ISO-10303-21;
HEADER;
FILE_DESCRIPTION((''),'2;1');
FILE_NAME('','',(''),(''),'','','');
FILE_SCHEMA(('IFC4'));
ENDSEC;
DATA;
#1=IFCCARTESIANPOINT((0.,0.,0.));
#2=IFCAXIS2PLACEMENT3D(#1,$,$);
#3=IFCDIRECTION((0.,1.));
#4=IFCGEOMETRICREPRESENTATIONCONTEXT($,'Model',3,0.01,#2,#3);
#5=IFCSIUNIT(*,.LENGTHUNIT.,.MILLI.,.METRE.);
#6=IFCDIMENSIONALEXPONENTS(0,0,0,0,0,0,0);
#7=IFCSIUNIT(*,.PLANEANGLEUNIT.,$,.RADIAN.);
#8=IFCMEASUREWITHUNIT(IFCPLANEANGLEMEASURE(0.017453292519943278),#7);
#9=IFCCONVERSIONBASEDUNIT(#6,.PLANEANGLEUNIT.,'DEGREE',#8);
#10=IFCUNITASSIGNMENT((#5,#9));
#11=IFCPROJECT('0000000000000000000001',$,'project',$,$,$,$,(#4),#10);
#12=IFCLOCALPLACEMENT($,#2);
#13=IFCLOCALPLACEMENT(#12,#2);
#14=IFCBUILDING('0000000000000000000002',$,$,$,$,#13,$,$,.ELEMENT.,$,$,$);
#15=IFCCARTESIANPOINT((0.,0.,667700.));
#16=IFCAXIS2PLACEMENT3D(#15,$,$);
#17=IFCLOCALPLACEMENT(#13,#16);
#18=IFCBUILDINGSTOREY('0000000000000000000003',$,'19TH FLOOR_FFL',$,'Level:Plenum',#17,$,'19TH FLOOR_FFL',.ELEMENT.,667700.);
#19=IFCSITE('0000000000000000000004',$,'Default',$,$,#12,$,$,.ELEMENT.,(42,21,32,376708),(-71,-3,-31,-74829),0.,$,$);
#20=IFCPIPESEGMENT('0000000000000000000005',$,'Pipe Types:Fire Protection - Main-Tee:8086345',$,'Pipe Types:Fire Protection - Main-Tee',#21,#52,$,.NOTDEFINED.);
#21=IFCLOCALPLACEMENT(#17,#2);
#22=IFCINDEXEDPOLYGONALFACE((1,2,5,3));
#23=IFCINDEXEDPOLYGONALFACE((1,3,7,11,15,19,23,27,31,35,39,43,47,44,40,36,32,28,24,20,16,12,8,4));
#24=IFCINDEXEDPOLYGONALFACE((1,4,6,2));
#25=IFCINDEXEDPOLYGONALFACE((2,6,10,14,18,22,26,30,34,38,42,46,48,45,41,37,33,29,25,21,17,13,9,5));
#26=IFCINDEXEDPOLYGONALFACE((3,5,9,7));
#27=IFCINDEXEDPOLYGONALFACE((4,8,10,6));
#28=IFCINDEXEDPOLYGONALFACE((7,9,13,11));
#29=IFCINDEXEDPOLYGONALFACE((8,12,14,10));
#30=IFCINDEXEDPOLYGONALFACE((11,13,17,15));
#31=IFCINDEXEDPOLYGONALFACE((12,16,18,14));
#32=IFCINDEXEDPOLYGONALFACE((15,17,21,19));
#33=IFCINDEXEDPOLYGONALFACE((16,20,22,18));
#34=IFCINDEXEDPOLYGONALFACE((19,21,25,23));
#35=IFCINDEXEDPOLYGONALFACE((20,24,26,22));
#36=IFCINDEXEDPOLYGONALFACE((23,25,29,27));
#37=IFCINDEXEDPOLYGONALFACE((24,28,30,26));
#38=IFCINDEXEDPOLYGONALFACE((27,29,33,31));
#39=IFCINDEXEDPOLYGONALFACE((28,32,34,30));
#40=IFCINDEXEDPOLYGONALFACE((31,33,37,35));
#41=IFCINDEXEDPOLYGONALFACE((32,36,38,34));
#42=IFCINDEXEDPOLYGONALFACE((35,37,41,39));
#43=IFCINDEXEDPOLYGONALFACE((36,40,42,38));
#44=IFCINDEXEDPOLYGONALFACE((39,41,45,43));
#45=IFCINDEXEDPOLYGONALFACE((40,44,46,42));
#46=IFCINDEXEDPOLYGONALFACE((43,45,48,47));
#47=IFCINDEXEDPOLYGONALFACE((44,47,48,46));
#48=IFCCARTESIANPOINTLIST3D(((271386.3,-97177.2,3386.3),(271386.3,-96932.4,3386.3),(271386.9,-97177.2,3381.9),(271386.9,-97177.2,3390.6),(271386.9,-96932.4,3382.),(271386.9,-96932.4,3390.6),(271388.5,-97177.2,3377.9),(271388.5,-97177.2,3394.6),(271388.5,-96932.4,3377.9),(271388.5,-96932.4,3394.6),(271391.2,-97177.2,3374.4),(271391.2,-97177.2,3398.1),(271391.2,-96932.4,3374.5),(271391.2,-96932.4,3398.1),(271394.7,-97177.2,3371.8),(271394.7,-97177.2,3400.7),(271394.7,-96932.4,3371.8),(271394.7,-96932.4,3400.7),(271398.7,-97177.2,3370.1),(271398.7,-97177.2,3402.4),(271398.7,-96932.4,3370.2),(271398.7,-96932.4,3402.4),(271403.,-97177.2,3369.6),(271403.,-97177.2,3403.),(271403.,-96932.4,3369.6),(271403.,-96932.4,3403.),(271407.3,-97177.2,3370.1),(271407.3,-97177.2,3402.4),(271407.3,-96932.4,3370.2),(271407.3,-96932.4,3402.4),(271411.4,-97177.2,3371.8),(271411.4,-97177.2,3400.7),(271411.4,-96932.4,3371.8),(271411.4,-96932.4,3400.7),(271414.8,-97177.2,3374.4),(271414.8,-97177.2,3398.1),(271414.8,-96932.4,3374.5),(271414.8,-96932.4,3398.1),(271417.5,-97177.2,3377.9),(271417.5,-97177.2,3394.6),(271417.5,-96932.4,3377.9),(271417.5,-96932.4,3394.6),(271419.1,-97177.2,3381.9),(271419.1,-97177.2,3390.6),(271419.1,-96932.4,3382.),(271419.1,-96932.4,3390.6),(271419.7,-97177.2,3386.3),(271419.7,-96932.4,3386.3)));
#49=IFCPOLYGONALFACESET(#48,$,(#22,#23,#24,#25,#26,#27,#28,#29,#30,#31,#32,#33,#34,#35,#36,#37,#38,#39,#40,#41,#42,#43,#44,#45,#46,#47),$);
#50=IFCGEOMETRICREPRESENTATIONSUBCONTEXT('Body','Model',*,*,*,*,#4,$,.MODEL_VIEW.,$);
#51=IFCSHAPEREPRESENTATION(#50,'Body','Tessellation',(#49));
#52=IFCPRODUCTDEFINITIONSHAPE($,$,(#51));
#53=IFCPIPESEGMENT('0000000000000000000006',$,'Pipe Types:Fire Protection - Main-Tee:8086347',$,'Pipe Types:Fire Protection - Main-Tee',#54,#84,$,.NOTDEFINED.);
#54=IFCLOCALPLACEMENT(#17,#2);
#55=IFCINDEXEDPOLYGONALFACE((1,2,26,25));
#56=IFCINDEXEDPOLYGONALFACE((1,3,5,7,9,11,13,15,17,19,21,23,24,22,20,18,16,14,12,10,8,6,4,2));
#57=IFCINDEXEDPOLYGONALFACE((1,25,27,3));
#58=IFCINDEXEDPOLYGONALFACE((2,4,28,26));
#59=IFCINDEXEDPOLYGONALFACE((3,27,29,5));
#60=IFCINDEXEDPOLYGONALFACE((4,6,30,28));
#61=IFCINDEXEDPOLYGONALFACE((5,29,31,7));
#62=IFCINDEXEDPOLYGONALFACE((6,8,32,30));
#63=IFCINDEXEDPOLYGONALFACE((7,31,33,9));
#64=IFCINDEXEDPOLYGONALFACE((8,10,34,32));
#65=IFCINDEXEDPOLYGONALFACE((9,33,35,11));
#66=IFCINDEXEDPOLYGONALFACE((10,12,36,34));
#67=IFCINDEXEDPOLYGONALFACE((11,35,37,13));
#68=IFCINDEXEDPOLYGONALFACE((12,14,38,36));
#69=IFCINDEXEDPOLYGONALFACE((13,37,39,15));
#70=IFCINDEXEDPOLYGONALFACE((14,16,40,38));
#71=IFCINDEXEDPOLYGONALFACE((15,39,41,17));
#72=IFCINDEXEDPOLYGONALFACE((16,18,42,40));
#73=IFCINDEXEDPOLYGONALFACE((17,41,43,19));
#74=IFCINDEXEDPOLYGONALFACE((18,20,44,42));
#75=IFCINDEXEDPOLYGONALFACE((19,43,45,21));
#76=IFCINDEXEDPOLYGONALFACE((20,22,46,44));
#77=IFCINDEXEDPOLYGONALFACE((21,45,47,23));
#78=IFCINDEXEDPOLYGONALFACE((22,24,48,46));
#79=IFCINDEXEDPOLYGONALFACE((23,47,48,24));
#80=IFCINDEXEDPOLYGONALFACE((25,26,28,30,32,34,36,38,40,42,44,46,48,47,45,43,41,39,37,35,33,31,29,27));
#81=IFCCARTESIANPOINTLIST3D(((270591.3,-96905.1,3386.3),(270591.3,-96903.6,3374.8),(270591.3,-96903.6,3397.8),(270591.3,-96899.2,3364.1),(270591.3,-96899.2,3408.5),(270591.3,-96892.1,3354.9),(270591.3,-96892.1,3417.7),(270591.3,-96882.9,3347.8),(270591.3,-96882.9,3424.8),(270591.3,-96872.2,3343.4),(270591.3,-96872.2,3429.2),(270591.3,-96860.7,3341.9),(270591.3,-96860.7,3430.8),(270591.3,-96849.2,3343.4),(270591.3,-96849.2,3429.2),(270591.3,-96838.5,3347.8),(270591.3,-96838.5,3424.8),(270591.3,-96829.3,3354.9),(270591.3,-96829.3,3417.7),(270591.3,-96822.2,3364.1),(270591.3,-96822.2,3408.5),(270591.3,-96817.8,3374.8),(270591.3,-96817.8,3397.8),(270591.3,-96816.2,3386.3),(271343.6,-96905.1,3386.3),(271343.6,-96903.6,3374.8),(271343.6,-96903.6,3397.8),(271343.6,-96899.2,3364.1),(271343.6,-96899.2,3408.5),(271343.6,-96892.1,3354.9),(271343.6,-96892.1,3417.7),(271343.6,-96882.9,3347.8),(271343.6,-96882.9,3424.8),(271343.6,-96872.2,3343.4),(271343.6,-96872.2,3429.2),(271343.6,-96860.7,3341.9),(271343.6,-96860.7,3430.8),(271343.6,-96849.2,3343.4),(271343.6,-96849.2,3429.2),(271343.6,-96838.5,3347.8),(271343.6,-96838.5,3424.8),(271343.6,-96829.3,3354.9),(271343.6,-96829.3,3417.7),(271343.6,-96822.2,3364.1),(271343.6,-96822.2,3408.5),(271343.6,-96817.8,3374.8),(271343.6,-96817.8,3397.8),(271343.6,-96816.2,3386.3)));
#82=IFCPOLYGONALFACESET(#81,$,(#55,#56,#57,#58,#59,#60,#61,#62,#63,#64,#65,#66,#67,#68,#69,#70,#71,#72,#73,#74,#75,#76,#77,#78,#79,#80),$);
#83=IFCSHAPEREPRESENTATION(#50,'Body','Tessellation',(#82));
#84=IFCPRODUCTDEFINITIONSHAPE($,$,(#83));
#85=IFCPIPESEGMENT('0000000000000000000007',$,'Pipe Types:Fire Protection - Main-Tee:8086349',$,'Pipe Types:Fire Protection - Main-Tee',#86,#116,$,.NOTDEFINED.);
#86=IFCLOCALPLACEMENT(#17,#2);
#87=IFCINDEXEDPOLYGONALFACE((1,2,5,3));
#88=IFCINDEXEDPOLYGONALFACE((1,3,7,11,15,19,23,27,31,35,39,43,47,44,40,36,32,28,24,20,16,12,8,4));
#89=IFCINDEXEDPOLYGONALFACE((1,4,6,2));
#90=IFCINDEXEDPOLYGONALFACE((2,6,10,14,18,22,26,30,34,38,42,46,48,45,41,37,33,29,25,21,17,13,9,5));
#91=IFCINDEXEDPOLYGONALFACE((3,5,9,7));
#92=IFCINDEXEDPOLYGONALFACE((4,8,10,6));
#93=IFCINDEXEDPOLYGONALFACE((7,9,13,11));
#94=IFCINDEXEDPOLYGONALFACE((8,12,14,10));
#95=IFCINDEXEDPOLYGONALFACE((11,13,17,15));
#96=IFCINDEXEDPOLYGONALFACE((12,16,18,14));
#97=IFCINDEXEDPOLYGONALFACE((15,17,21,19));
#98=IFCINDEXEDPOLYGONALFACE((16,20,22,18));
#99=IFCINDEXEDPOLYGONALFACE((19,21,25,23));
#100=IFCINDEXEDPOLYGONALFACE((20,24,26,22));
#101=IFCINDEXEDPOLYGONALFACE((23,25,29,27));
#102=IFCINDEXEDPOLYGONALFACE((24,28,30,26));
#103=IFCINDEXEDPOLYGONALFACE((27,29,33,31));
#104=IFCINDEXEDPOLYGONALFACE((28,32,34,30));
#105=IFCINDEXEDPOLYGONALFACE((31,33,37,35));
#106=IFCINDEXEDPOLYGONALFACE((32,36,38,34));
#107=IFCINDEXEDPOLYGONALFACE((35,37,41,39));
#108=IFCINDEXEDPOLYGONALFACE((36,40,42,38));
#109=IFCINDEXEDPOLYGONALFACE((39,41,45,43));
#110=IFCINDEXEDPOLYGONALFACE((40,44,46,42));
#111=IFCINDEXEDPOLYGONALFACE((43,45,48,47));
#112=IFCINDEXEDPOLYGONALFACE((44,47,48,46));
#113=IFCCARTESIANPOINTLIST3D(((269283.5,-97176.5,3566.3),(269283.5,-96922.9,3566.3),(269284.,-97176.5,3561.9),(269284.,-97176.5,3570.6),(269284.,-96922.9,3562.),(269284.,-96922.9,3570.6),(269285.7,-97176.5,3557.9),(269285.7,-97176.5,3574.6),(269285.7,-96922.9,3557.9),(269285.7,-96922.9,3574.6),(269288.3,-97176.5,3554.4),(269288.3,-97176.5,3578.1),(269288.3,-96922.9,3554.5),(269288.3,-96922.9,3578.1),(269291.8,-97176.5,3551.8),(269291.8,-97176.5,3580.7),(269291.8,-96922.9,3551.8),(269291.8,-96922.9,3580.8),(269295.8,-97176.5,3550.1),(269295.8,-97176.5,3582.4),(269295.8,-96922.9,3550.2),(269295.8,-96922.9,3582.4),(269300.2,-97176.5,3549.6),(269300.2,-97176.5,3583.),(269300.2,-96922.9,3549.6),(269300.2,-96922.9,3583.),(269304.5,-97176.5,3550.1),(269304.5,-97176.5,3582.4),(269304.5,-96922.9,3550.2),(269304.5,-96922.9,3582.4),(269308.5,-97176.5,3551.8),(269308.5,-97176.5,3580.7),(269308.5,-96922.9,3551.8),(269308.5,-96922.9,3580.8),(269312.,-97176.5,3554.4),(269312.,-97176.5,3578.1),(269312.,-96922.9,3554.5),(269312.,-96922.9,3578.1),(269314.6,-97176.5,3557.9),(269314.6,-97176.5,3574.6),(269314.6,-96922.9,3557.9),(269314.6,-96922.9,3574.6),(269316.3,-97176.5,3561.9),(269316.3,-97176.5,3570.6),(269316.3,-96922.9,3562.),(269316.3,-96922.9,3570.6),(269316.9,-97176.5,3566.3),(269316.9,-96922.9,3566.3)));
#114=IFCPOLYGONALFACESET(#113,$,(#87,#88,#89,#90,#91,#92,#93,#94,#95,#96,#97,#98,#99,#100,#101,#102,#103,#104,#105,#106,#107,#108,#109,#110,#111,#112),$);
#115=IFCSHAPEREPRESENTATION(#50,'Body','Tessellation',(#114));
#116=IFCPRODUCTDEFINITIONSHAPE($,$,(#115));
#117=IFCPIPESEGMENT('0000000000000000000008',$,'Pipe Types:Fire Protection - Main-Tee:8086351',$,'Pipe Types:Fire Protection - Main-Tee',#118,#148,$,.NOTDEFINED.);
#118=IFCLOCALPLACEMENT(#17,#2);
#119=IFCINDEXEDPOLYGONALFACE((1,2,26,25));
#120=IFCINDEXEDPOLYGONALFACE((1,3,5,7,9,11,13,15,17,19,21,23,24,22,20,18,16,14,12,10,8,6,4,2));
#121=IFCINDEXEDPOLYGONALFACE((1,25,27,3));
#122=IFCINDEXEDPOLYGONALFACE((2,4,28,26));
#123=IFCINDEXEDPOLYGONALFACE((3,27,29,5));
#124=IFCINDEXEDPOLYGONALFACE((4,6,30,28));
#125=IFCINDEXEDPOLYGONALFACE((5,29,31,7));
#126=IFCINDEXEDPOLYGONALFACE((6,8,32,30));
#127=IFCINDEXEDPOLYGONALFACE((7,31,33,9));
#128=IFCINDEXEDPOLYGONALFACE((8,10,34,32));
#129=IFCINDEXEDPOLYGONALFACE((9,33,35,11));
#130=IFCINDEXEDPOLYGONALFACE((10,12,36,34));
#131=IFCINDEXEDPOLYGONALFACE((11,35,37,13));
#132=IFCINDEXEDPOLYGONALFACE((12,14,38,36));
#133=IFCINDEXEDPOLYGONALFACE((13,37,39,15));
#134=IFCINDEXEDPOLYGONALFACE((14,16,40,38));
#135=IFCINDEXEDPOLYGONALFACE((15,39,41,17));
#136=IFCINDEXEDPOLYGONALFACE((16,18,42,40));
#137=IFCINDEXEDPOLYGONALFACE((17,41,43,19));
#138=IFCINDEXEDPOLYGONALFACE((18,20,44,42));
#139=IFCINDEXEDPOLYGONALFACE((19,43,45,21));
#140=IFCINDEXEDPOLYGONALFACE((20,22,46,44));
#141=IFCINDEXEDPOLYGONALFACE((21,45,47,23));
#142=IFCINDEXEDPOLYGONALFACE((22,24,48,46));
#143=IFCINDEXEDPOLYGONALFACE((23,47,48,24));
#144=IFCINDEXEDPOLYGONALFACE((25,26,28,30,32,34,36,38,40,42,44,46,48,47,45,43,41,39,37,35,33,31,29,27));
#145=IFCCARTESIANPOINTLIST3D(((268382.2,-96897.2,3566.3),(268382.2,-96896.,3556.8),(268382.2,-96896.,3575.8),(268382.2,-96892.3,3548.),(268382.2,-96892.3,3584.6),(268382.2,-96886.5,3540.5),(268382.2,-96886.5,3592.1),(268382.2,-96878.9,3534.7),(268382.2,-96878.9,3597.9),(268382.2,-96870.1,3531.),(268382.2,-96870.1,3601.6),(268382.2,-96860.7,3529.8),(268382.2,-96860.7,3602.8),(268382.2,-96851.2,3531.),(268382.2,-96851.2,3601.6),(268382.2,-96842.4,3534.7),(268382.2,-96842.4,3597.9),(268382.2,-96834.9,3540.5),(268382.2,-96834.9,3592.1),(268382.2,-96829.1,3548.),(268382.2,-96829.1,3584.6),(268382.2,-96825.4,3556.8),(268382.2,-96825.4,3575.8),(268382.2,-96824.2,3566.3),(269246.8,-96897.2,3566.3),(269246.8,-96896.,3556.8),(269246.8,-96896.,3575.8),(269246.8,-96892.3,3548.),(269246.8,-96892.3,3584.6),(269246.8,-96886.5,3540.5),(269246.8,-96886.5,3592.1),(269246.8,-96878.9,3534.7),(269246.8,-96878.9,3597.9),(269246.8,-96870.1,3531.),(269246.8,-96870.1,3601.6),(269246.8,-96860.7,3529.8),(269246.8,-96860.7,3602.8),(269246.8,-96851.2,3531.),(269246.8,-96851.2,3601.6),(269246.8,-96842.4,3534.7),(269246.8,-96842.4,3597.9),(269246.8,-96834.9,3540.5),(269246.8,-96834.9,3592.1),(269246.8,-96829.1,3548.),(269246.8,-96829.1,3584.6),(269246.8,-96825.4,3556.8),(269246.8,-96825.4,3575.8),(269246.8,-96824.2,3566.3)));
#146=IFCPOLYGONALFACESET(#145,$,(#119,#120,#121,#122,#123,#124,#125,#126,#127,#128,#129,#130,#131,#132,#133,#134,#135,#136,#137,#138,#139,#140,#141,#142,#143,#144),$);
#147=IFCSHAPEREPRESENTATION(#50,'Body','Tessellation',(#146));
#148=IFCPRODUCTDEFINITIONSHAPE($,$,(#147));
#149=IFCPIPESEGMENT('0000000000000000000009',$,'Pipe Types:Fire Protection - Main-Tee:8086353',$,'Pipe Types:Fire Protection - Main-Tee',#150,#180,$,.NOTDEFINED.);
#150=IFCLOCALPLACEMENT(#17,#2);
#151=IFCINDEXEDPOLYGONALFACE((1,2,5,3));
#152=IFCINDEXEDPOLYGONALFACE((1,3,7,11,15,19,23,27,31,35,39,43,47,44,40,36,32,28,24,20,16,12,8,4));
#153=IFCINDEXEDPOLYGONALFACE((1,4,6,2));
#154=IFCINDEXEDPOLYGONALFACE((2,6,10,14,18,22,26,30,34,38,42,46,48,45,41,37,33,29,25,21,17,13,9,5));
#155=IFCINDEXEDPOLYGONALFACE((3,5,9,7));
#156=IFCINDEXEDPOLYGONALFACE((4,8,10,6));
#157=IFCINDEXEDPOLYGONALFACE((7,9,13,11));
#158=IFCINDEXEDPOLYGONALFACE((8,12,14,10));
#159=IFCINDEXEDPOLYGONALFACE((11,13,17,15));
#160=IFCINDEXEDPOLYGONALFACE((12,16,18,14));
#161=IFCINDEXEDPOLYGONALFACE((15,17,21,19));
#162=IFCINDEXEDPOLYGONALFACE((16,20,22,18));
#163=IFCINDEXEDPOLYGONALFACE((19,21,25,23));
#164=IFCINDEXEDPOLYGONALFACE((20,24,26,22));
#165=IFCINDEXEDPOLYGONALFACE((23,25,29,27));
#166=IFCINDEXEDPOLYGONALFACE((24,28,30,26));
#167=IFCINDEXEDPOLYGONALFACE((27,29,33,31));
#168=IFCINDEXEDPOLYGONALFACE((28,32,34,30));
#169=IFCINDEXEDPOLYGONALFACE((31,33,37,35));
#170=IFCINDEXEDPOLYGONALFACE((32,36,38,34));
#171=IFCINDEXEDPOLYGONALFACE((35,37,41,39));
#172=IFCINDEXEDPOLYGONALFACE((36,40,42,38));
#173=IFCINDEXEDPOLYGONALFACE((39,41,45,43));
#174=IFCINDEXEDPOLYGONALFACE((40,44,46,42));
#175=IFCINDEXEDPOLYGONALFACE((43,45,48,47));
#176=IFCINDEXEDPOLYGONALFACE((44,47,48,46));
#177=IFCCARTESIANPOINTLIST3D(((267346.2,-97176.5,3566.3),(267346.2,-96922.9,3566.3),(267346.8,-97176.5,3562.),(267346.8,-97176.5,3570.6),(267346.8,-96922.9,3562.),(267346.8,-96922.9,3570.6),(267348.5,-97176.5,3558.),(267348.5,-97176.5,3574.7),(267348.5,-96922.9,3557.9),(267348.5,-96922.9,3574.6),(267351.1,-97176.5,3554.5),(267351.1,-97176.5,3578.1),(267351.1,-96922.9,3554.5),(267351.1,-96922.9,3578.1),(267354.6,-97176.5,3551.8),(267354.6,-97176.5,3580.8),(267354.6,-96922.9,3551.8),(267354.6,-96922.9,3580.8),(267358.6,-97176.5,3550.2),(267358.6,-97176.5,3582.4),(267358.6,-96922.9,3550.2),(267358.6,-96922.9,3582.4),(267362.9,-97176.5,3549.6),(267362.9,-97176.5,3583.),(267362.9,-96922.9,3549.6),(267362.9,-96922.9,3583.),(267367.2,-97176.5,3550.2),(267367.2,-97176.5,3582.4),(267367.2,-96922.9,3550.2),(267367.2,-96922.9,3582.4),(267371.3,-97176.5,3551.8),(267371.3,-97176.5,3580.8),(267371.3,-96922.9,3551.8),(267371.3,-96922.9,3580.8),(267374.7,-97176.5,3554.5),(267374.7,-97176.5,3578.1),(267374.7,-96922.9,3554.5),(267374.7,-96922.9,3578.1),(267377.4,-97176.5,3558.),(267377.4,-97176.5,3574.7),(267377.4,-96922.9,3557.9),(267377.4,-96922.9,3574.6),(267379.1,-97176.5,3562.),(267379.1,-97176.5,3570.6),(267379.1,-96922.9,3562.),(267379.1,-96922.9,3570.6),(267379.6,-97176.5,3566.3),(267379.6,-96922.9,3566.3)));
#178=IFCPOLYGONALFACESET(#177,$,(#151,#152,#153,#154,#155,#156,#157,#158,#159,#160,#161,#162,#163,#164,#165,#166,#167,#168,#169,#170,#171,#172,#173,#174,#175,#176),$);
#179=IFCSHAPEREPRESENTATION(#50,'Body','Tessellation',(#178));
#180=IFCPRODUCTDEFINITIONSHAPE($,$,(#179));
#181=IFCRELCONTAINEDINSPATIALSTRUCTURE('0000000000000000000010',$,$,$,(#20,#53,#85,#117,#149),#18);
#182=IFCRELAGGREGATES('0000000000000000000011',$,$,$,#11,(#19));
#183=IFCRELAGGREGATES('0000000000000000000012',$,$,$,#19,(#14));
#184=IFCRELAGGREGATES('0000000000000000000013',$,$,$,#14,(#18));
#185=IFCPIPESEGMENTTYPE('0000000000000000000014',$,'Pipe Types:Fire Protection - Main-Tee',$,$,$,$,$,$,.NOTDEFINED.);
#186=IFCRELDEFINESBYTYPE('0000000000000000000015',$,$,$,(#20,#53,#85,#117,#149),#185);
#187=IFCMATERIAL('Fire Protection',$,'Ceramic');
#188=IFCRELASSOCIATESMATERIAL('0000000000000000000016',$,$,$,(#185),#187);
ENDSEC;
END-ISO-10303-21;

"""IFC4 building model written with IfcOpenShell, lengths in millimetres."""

from ifc_helpers import new_model, entity, si_unit, converted_unit, direction, frame, origin, place, context, subcontext, project, spatial, arc, indexed_curve, outline, extrude, material, type_object, element, save


model = new_model("IFC4")

# Units and contexts
model_context = context("Model", 3, precision=0.01, world=origin(), true_north=direction((0.0, 1.0)))
body_context = subcontext(model_context, "Body", "Model", "MODEL_VIEW")
ifc_project = project(units=[si_unit("LENGTHUNIT", "METRE", prefix="MILLI"), converted_unit("PLANEANGLEUNIT", "DEGREE", entity("IfcPlaneAngleMeasure", 0.017453292519943278), si_unit("PLANEANGLEUNIT", "RADIAN"), dimensions=[0, 0, 0, 0, 0, 0, 0])], contexts=[model_context])

# Site, building, storey
site_placement = place(None, origin())
site = spatial("IfcSite", under=ifc_project, at=site_placement, Name="Default", CompositionType="ELEMENT", RefLatitude=(42, 21, 32, 376708), RefLongitude=(-71, -3, -31, -74829), RefElevation=0.0)
building_placement = place(site_placement, origin())
building = spatial("IfcBuilding", under=site, at=building_placement, CompositionType="ELEMENT")
storey_placement = place(building_placement, frame((0.0, 0.0, 667700.0)))
storey = spatial("IfcBuildingStorey", under=building, at=storey_placement, Name="19TH FLOOR_FFL", ObjectType="Level:Plenum", LongName="19TH FLOOR_FFL", CompositionType="ELEMENT", Elevation=667700.0)

# Pipe segments
ifc_material_1 = material(Name="Fire Protection", Category="Ceramic")
pipe_segment_type = type_object("IfcPipeSegmentType", Name="Pipe Types:Fire Protection - Main-Tee", PredefinedType="NOTDEFINED", material=ifc_material_1)
pipe_segment_1_placement = place(storey_placement, origin())
element("IfcPipeSegment", 1, at=pipe_segment_1_placement, inside=storey, type_object=pipe_segment_type, Name="Pipe Types:Fire Protection - Main-Tee:8086345", ObjectType="Pipe Types:Fire Protection - Main-Tee", PredefinedType="NOTDEFINED", context=body_context, shape_type="SweptSolid", body=[
    extrude(outline(indexed_curve([(16.7, 0.0), (11.8, 11.8), (0.0, 16.7), (-11.8, 11.8), (-16.7, 0.0), (-11.8, -11.8), (0.0, -16.7), (11.8, -11.8)], segments=[arc(1, 2, 3), arc(3, 4, 5), arc(5, 6, 7), arc(7, 8, 1)], self_intersect=False)), frame((271403.0, -97177.2, 3386.3), z_axis=(0.0, 1.0, 0.000143), x_axis=(-1.0, 0.0, 0.0)), (0.0, 0.0, 1.0), 244.8),
])
pipe_segment_2_placement = place(storey_placement, origin())
element("IfcPipeSegment", 2, at=pipe_segment_2_placement, inside=storey, type_object=pipe_segment_type, Name="Pipe Types:Fire Protection - Main-Tee:8086347", ObjectType="Pipe Types:Fire Protection - Main-Tee", PredefinedType="NOTDEFINED", context=body_context, shape_type="SweptSolid", body=[
    extrude(outline(indexed_curve([(44.4, 0.0), (31.4, 31.4), (0.0, 44.5), (-31.4, 31.4), (-44.4, 0.0), (-31.4, -31.4), (0.0, -44.5), (31.4, -31.4)], segments=[arc(1, 2, 3), arc(3, 4, 5), arc(5, 6, 7), arc(7, 8, 1)], self_intersect=False)), frame((270591.3, -96860.7, 3386.3), z_axis=(1.0, 0.0, 0.0), x_axis=(0.0, 1.0, 0.0)), (0.0, 0.0, 1.0), 752.3),
])
pipe_segment_3_placement = place(storey_placement, origin())
element("IfcPipeSegment", 3, at=pipe_segment_3_placement, inside=storey, type_object=pipe_segment_type, Name="Pipe Types:Fire Protection - Main-Tee:8086349", ObjectType="Pipe Types:Fire Protection - Main-Tee", PredefinedType="NOTDEFINED", context=body_context, shape_type="SweptSolid", body=[
    extrude(outline(indexed_curve([(16.7, 0.0), (11.8, 11.8), (0.0, 16.7), (-11.8, 11.8), (-16.7, 0.0), (-11.8, -11.8), (0.0, -16.7), (11.8, -11.8)], segments=[arc(1, 2, 3), arc(3, 4, 5), arc(5, 6, 7), arc(7, 8, 1)], self_intersect=False)), frame((269300.2, -97176.5, 3566.3), z_axis=(0.0, 1.0, 0.00014), x_axis=(-1.0, 0.0, 0.0)), (0.0, 0.0, 1.0), 253.5),
])
pipe_segment_4_placement = place(storey_placement, origin())
element("IfcPipeSegment", 4, at=pipe_segment_4_placement, inside=storey, type_object=pipe_segment_type, Name="Pipe Types:Fire Protection - Main-Tee:8086351", ObjectType="Pipe Types:Fire Protection - Main-Tee", PredefinedType="NOTDEFINED", context=body_context, shape_type="SweptSolid", body=[
    extrude(outline(indexed_curve([(36.5, 0.0), (25.8, 25.8), (0.0, 36.5), (-25.8, 25.8), (-36.5, 0.0), (-25.8, -25.8), (0.0, -36.5), (25.8, -25.8)], segments=[arc(1, 2, 3), arc(3, 4, 5), arc(5, 6, 7), arc(7, 8, 1)], self_intersect=False)), frame((268382.2, -96860.7, 3566.3), z_axis=(1.0, 0.0, 0.0), x_axis=(0.0, 1.0, 0.0)), (0.0, 0.0, 1.0), 864.6),
])
pipe_segment_5_placement = place(storey_placement, origin())
element("IfcPipeSegment", 5, at=pipe_segment_5_placement, inside=storey, type_object=pipe_segment_type, Name="Pipe Types:Fire Protection - Main-Tee:8086353", ObjectType="Pipe Types:Fire Protection - Main-Tee", PredefinedType="NOTDEFINED", context=body_context, shape_type="SweptSolid", body=[
    extrude(outline(indexed_curve([(16.7, 0.0), (11.8, 11.8), (0.0, 16.7), (-11.8, 11.8), (-16.7, 0.0), (-11.8, -11.8), (0.0, -16.7), (11.8, -11.8)], segments=[arc(1, 2, 3), arc(3, 4, 5), arc(5, 6, 7), arc(7, 8, 1)], self_intersect=False)), frame((267362.9, -97176.5, 3566.3), z_axis=(0.0, 1.0, -0.000015), x_axis=(-1.0, 0.0, 0.0)), (0.0, 0.0, 1.0), 253.5),
])

save(model, "model.ifc")
